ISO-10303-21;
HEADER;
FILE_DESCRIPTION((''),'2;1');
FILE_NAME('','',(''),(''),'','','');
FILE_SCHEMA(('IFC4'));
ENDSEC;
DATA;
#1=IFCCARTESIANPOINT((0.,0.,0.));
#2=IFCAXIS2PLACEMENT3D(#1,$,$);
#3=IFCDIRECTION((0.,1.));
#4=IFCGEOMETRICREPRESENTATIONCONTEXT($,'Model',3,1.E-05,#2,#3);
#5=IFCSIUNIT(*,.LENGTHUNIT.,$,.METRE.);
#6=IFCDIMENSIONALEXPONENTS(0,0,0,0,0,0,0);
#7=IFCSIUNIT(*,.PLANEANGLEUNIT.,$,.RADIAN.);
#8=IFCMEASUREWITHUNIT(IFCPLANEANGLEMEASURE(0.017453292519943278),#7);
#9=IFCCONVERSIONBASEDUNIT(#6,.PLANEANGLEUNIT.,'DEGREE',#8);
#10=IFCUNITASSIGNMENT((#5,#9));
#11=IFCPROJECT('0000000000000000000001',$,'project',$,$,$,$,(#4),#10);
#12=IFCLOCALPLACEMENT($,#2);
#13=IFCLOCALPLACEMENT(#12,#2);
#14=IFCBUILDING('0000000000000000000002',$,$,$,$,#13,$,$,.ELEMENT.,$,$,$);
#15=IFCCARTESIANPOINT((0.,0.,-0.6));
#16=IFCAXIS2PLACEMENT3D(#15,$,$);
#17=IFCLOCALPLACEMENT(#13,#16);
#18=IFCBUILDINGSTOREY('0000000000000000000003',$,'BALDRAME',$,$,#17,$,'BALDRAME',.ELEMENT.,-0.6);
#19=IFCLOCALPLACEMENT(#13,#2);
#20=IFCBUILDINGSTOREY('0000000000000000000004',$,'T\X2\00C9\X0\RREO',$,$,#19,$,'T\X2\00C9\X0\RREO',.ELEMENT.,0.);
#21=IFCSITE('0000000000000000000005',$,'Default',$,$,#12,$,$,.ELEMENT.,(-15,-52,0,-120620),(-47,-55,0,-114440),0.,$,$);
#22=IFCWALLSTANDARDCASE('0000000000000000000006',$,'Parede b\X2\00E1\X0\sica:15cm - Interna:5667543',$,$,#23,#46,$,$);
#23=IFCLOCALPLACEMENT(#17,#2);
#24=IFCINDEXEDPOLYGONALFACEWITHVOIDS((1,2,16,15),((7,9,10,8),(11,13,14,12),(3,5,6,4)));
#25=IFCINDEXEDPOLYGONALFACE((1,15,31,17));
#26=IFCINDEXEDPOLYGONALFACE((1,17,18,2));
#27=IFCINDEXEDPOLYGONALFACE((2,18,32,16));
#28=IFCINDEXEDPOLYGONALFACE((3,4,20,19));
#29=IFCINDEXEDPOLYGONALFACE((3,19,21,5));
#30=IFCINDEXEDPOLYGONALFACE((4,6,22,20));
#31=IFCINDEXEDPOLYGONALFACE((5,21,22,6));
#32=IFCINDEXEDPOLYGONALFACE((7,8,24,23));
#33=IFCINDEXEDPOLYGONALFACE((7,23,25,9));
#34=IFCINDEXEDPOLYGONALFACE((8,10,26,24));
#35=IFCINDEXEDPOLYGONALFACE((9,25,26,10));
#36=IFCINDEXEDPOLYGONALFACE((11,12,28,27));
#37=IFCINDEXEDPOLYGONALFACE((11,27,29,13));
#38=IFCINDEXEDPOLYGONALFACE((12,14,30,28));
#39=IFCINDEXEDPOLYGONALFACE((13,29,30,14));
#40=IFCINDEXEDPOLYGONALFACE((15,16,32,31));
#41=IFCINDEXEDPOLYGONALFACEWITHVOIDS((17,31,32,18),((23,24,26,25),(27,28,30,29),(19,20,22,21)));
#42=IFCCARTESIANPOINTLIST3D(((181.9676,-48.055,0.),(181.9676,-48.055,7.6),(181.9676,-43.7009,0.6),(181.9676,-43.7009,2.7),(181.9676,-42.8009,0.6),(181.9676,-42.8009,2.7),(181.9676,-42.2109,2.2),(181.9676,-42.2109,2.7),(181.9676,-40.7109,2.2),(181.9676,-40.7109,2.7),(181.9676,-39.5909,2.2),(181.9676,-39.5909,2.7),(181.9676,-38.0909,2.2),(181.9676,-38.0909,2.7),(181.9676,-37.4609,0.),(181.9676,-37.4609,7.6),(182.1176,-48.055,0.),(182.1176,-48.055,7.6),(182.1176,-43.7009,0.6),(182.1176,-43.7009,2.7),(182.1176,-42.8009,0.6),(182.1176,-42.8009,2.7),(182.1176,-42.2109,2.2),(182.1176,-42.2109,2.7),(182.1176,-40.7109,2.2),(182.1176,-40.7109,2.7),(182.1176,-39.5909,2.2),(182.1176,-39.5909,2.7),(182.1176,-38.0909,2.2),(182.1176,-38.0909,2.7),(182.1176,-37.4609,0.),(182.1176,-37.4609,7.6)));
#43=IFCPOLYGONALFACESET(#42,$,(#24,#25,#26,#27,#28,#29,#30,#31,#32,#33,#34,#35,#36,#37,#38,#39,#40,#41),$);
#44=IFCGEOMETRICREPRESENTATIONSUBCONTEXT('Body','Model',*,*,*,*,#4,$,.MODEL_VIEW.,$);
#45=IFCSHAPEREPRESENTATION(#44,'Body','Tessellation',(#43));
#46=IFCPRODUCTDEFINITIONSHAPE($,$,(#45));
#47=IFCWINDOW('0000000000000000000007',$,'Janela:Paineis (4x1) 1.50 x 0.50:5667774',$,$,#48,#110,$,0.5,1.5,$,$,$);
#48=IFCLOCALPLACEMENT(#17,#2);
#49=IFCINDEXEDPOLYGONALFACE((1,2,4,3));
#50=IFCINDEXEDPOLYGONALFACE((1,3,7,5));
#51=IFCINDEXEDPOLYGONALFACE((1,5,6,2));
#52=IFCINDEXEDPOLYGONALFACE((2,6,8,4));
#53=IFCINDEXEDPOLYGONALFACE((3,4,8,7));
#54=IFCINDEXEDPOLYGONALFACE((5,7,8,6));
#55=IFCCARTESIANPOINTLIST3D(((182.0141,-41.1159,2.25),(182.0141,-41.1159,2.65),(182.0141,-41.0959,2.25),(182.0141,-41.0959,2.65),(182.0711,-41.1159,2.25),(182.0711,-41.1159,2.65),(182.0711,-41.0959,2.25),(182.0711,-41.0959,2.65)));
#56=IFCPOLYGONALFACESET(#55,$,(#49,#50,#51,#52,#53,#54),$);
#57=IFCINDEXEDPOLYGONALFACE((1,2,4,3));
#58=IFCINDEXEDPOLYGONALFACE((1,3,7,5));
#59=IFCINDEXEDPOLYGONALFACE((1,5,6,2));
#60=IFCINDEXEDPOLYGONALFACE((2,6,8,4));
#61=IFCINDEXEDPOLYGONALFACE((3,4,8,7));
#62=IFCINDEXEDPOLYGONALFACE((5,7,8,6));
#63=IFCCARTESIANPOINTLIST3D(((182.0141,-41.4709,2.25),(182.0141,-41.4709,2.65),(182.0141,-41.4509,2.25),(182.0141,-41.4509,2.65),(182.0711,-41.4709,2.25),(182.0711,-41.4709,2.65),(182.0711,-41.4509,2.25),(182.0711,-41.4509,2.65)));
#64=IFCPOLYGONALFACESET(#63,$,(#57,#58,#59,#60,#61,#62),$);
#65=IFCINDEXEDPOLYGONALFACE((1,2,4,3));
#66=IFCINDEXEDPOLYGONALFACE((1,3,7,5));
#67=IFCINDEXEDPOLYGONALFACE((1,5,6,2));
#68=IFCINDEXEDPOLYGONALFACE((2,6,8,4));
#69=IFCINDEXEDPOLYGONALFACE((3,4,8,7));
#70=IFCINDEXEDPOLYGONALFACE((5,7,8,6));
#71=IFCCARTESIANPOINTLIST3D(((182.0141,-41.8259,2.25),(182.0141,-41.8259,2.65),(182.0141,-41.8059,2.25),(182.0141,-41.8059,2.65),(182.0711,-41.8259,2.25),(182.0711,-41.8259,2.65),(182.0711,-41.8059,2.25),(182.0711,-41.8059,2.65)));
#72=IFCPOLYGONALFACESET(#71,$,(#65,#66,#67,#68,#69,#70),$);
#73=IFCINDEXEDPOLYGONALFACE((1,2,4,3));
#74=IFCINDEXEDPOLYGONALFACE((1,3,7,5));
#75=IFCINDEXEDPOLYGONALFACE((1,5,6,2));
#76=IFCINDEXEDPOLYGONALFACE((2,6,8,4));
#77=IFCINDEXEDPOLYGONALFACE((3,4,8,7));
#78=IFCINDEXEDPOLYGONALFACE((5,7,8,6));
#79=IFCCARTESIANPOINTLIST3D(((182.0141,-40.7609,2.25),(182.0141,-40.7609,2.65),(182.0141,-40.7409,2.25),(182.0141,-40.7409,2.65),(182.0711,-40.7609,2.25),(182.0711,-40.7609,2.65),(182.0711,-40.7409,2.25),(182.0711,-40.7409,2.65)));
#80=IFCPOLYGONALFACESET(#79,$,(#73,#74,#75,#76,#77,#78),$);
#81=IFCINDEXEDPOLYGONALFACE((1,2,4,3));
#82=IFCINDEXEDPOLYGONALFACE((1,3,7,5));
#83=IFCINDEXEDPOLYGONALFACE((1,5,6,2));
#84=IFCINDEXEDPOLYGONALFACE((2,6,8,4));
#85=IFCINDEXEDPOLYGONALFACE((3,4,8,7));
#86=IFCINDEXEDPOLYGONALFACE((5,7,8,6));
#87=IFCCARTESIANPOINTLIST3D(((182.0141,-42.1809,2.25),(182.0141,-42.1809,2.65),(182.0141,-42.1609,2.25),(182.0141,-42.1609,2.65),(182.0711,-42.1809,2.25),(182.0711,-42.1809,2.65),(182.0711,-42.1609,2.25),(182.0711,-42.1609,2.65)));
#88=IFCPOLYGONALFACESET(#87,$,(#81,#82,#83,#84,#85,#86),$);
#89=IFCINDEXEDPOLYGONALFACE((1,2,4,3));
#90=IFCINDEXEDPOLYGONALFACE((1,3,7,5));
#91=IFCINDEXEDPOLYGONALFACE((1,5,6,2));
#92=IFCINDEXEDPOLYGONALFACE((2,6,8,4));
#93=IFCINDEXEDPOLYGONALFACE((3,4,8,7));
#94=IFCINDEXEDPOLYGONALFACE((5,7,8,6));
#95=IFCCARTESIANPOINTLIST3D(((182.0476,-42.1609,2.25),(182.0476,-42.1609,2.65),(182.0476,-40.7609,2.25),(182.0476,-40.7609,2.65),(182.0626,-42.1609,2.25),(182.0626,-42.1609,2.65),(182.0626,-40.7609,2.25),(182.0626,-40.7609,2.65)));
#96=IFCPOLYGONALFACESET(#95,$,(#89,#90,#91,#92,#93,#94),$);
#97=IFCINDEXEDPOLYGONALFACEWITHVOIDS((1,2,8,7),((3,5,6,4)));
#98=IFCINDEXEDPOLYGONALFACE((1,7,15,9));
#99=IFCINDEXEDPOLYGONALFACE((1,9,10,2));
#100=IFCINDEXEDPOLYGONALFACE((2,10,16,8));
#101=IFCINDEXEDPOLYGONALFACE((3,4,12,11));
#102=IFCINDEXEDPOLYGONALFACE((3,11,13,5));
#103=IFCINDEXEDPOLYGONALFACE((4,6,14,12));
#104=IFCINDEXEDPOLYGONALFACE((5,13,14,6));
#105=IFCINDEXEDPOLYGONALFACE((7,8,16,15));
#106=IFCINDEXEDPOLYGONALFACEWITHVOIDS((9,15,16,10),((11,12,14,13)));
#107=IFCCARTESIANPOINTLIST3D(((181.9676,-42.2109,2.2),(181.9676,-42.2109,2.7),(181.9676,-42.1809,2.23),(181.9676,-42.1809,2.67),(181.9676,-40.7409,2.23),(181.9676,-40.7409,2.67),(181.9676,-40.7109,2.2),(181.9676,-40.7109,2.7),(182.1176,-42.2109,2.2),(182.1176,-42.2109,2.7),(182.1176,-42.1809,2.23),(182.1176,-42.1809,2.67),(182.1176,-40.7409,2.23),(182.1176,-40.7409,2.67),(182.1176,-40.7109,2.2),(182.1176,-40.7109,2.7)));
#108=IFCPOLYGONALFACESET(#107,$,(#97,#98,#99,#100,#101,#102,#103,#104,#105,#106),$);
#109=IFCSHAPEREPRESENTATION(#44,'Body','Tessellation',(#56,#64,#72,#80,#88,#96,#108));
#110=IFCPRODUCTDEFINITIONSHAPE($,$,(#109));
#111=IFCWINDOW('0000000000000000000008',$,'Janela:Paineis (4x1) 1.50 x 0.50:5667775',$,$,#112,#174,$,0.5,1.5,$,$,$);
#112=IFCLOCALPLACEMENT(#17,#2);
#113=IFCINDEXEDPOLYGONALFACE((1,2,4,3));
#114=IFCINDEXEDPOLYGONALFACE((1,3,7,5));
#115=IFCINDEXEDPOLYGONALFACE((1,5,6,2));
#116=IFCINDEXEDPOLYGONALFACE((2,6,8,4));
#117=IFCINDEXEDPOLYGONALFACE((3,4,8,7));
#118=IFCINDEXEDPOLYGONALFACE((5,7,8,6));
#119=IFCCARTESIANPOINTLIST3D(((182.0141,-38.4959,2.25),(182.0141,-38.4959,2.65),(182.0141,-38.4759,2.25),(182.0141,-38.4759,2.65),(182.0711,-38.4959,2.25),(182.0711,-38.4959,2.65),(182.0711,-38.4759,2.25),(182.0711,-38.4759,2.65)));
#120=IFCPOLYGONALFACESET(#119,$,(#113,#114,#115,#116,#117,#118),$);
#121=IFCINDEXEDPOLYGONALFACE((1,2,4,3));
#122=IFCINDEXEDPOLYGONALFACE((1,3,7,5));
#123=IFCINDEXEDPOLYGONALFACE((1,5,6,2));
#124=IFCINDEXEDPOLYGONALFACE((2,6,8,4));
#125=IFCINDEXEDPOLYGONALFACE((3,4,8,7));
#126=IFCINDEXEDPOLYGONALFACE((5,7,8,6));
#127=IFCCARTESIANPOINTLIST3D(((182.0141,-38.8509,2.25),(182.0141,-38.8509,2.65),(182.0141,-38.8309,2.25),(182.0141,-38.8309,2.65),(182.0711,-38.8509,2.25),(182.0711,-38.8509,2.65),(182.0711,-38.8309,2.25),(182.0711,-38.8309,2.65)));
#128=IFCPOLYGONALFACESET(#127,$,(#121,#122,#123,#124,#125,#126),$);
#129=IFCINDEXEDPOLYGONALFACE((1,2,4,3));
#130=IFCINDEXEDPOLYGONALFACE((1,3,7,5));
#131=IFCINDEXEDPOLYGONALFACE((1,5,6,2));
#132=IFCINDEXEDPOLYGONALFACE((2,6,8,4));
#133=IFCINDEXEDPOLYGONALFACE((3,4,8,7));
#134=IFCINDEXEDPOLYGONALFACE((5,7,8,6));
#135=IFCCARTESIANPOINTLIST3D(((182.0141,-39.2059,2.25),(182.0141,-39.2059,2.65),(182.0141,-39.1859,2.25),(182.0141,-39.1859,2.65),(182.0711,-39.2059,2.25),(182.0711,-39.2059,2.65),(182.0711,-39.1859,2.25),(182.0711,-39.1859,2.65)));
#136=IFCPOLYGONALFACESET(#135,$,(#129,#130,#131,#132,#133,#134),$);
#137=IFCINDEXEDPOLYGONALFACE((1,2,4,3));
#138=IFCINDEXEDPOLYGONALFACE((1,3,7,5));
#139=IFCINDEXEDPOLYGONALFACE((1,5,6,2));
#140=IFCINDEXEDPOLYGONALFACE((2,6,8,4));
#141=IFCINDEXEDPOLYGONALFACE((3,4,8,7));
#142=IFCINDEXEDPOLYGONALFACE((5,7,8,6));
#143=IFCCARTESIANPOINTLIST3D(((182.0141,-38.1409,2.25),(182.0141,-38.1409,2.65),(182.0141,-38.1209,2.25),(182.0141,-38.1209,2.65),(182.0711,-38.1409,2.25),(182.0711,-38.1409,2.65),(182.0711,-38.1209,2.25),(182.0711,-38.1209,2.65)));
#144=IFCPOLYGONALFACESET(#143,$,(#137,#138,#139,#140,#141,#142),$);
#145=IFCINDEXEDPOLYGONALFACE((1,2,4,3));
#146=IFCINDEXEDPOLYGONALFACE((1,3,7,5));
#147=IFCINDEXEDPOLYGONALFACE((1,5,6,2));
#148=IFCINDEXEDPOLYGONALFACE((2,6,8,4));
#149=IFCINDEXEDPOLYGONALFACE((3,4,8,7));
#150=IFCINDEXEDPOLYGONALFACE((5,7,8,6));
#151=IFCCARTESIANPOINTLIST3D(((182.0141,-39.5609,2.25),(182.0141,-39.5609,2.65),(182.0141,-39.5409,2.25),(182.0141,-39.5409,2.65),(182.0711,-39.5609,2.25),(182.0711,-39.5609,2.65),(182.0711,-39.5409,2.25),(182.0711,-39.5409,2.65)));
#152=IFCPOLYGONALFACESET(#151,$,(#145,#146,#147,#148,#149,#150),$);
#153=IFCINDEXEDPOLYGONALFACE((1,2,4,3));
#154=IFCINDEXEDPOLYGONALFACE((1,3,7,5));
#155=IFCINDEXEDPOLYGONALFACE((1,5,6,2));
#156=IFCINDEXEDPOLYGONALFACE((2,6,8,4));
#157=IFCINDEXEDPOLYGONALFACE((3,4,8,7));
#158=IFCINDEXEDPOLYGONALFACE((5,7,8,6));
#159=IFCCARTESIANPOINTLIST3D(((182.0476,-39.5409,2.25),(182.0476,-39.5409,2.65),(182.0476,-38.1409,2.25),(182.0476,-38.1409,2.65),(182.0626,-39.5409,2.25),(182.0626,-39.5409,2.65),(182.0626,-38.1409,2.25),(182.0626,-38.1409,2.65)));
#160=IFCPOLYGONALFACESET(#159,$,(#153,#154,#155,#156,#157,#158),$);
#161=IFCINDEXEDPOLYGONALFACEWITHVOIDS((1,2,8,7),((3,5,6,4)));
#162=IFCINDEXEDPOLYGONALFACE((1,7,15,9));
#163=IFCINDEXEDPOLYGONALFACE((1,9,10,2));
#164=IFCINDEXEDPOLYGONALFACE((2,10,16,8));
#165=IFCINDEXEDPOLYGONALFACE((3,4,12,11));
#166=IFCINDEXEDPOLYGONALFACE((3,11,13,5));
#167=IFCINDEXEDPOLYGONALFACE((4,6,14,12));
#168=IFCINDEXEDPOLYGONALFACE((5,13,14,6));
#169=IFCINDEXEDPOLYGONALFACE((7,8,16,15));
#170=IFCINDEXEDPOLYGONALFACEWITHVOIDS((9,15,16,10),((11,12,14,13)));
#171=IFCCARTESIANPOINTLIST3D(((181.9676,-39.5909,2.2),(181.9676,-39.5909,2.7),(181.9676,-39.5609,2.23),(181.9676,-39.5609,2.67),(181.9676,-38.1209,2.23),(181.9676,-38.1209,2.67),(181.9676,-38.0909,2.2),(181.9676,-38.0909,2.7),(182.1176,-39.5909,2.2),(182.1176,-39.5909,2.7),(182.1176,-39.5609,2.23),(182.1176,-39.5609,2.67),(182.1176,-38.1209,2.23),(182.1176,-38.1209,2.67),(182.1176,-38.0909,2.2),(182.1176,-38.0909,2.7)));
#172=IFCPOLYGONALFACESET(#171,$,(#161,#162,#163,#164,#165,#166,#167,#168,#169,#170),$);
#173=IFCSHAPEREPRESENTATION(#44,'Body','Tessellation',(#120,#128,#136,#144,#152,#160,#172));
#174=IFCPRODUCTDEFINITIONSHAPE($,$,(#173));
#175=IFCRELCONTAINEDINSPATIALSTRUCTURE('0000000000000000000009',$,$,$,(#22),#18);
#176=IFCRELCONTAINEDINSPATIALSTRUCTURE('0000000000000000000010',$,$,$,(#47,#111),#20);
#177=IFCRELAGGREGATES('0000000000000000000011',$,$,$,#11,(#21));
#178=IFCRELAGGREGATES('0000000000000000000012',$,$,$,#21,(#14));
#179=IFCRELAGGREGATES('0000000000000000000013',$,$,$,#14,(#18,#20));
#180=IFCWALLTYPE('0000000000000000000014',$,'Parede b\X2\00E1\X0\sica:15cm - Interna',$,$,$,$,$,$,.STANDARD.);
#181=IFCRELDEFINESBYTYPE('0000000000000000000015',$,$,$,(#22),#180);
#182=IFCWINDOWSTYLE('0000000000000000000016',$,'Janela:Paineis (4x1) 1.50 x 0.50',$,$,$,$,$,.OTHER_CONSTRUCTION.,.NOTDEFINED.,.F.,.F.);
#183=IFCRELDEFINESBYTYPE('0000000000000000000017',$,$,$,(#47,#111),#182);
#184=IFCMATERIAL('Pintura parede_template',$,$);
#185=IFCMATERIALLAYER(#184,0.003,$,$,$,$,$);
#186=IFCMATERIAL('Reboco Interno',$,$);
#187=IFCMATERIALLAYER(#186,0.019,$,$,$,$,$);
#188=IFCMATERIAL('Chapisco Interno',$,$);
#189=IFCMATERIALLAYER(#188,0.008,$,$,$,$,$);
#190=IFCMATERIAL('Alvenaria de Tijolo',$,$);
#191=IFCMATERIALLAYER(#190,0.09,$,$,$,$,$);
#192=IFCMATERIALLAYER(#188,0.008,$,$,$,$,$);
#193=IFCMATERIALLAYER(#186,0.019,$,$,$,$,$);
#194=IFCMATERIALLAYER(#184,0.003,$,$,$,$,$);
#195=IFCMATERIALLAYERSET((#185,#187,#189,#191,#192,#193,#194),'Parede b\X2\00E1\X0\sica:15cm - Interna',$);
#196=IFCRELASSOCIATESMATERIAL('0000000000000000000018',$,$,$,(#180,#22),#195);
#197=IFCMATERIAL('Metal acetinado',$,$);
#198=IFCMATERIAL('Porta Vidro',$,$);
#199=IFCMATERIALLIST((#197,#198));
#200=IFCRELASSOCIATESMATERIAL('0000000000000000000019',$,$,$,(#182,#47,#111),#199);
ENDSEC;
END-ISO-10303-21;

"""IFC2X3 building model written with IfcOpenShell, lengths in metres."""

from ifc_helpers import new_model, entity, si_unit, converted_unit, direction, frame, frame_2d, origin, origin_2d_with_axis, place, context, subcontext, project, spatial, polyline, rectangle, outline, extrude, source, transform, mapped, material, material_list, layer, layer_set, layer_usage, type_object, type_shapes, element, fill, save


model = new_model("IFC2X3")

# Units and contexts
model_context = context("Model", 3, precision=1e-05, world=origin(), true_north=direction((0.0, 1.0)))
body_context = subcontext(model_context, "Body", "Model", "MODEL_VIEW")
ifc_project = project(units=[si_unit("LENGTHUNIT", "METRE"), converted_unit("PLANEANGLEUNIT", "DEGREE", entity("IfcPlaneAngleMeasure", 0.017453292519943278), si_unit("PLANEANGLEUNIT", "RADIAN"), dimensions=[0, 0, 0, 0, 0, 0, 0])], contexts=[model_context])

# Site, building, storey
site_placement = place(None, origin())
site = spatial("IfcSite", under=ifc_project, at=site_placement, Name="Default", CompositionType="ELEMENT", RefLatitude=(-15, -52, 0, -120620), RefLongitude=(-47, -55, 0, -114440), RefElevation=0.0)
building_placement = place(site_placement, origin())
building = spatial("IfcBuilding", under=site, at=building_placement, CompositionType="ELEMENT")
storey_1_placement = place(building_placement, frame((0.0, 0.0, -0.6)))
storey_1 = spatial("IfcBuildingStorey", under=building, at=storey_1_placement, Name="BALDRAME", LongName="BALDRAME", CompositionType="ELEMENT", Elevation=-0.6)

# Wall, openings
ifc_material_1 = material(Name="Pintura parede_template")
ifc_layer_1 = layer(ifc_material_1, 0.003)
ifc_material_2 = material(Name="Reboco Interno")
ifc_layer_2 = layer(ifc_material_2, 0.019)
ifc_material_3 = material(Name="Chapisco Interno")
ifc_layer_3 = layer(ifc_material_3, 0.008)
ifc_material_4 = material(Name="Alvenaria de Tijolo")
ifc_layer_4 = layer(ifc_material_4, 0.09)
ifc_layer_5 = layer(ifc_material_3, 0.008)
ifc_layer_6 = layer(ifc_material_2, 0.019)
ifc_layer_7 = layer(ifc_material_1, 0.003)
ifc_layer_set_1 = layer_set([ifc_layer_1, ifc_layer_2, ifc_layer_3, ifc_layer_4, ifc_layer_5, ifc_layer_6, ifc_layer_7], Name="Parede básica:15cm - Interna")
ifc_layer_usage_1 = layer_usage(ifc_layer_set_1, "AXIS2", "NEGATIVE", 0.075)
wall_type_1 = type_object("IfcWallType", Name="Parede básica:15cm - Interna", PredefinedType="STANDARD", material=ifc_layer_set_1)
wall_1_placement = place(storey_1_placement, frame((182.0426, -48.055, 0.0), z_axis=(0.0, 0.0, 1.0), x_axis=(0.0, 1.0, 0.0)))
wall_1 = element("IfcWallStandardCase", 1, at=wall_1_placement, inside=storey_1, type_object=wall_type_1, material=ifc_layer_usage_1, Name="Parede básica:15cm - Interna:5667543", context=body_context, shape_type="SweptSolid", body=[
    extrude(rectangle(XDim=10.5941, YDim=0.15, at=frame_2d((5.2971, 0.0), x_axis=(-1.0, 0.0))), origin(), (0.0, 0.0, 1.0), 7.6),
])
opening_1_placement = place(wall_1_placement, frame((4.3541, -0.075, 0.6)))
element("IfcOpeningElement", 2, at=opening_1_placement, cuts=wall_1, ObjectType="Opening", context=body_context, shape_type="SweptSolid", body=[
    extrude(rectangle(XDim=0.9, YDim=2.1, at=frame_2d((1.05, 0.45), x_axis=(0.0, 1.0))), frame((0.0, 0.0, 0.0), z_axis=(0.0, 1.0, 0.0), x_axis=(0.0, 0.0, 1.0)), (0.0, 0.0, 1.0), 0.15),
])
opening_2_placement = place(wall_1_placement, frame((5.8441, -0.075, 2.2)))
opening_2 = element("IfcOpeningElement", 3, at=opening_2_placement, cuts=wall_1, ObjectType="Opening", context=body_context, shape_type="SweptSolid", body=[
    extrude(rectangle(XDim=0.5, YDim=1.5, at=frame_2d((0.25, 0.75), x_axis=(1.0, 0.0))), frame((0.0, 0.0, 0.0), z_axis=(0.0, 1.0, 0.0), x_axis=(0.0, 0.0, 1.0)), (0.0, 0.0, 1.0), 0.15),
])
opening_3_placement = place(wall_1_placement, frame((8.4641, -0.075, 2.2)))
opening_3 = element("IfcOpeningElement", 4, at=opening_3_placement, cuts=wall_1, ObjectType="Opening", context=body_context, shape_type="SweptSolid", body=[
    extrude(rectangle(XDim=0.5, YDim=1.5, at=frame_2d((0.25, 0.75), x_axis=(1.0, 0.0))), frame((0.0, 0.0, 0.0), z_axis=(0.0, 1.0, 0.0), x_axis=(0.0, 0.0, 1.0)), (0.0, 0.0, 1.0), 0.15),
])

# Shared definitions
storey_2_placement = place(building_placement, origin())
storey_2 = spatial("IfcBuildingStorey", under=building, at=storey_2_placement, Name="TÉRREO", LongName="TÉRREO", CompositionType="ELEMENT", Elevation=0.0)

# Windows
ifc_material_5 = material(Name="Metal acetinado")
ifc_material_6 = material(Name="Porta Vidro")
ifc_material_list = material_list([ifc_material_5, ifc_material_6])
window_style = type_object("IfcWindowStyle", Name="Janela:Paineis (4x1) 1.50 x 0.50", ConstructionType="OTHER_CONSTRUCTION", OperationType="NOTDEFINED", ParameterTakesPrecedence=False, Sizeable=False, material=ifc_material_list)
shared_shape = source(origin(), body_context, "Body", "SweptSolid", [
    extrude(rectangle(XDim=0.057, YDim=0.02, at=frame_2d((0.0, 0.0), x_axis=(1.0, 0.0))), frame((1.105, 0.075, 0.05), z_axis=(0.0, 0.0, 1.0), x_axis=(0.0, -1.0, 0.0)), (0.0, 0.0, 1.0), 0.4),
    extrude(rectangle(XDim=0.057, YDim=0.02, at=origin_2d_with_axis()), frame((0.75, 0.075, 0.05), z_axis=(0.0, 0.0, 1.0), x_axis=(0.0, -1.0, 0.0)), (0.0, 0.0, 1.0), 0.4),
    extrude(rectangle(XDim=0.057, YDim=0.02, at=frame_2d((0.0, 0.0), x_axis=(1.0, 0.0))), frame((0.395, 0.075, 0.05), z_axis=(0.0, 0.0, 1.0), x_axis=(0.0, -1.0, 0.0)), (0.0, 0.0, 1.0), 0.4),
    extrude(rectangle(XDim=0.057, YDim=0.02, at=origin_2d_with_axis()), frame((1.46, 0.075, 0.05), z_axis=(0.0, 0.0, 1.0), x_axis=(0.0, -1.0, 0.0)), (0.0, 0.0, 1.0), 0.4),
    extrude(rectangle(XDim=0.057, YDim=0.02, at=origin_2d_with_axis()), frame((0.04, 0.075, 0.05), z_axis=(0.0, 0.0, 1.0), x_axis=(0.0, -1.0, 0.0)), (0.0, 0.0, 1.0), 0.4),
    extrude(rectangle(XDim=1.4, YDim=0.015, at=frame_2d((0.0, 0.0), x_axis=(1.0, 0.0))), frame((0.75, 0.0625, 0.05)), (0.0, 0.0, 1.0), 0.4),
    extrude(outline(polyline([(-0.75, -0.25), (0.75, -0.25), (0.75, 0.25), (-0.75, 0.25), (-0.75, -0.25)]), holes=[polyline([(0.72, -0.22), (-0.72, -0.22), (-0.72, 0.22), (0.72, 0.22), (0.72, -0.22)])]), frame((0.75, 0.15, 0.25), z_axis=(0.0, -1.0, 0.0), x_axis=(-1.0, 0.0, 0.0)), (0.0, 0.0, 1.0), 0.15),
])
type_shapes(window_style, [shared_shape])
window_1_placement = place(opening_2_placement, origin())
window_1 = element("IfcWindow", 5, at=window_1_placement, inside=storey_2, type_object=window_style, material=ifc_material_list, Name="Janela:Paineis (4x1) 1.50 x 0.50:5667774", OverallHeight=0.5, OverallWidth=1.5, context=body_context, shape_type="MappedRepresentation", body=[
    mapped(shared_shape, transform((0.0, 0.0, 0.0), scale=1.0)),
])
fill(opening_2, window_1)
window_2_placement = place(opening_3_placement, origin())
window_2 = element("IfcWindow", 6, at=window_2_placement, inside=storey_2, type_object=window_style, material=ifc_material_list, Name="Janela:Paineis (4x1) 1.50 x 0.50:5667775", OverallHeight=0.5, OverallWidth=1.5, context=body_context, shape_type="MappedRepresentation", body=[
    mapped(shared_shape, transform((0.0, 0.0, 0.0), scale=1.0)),
])
fill(opening_3, window_2)

save(model, "model.ifc")
